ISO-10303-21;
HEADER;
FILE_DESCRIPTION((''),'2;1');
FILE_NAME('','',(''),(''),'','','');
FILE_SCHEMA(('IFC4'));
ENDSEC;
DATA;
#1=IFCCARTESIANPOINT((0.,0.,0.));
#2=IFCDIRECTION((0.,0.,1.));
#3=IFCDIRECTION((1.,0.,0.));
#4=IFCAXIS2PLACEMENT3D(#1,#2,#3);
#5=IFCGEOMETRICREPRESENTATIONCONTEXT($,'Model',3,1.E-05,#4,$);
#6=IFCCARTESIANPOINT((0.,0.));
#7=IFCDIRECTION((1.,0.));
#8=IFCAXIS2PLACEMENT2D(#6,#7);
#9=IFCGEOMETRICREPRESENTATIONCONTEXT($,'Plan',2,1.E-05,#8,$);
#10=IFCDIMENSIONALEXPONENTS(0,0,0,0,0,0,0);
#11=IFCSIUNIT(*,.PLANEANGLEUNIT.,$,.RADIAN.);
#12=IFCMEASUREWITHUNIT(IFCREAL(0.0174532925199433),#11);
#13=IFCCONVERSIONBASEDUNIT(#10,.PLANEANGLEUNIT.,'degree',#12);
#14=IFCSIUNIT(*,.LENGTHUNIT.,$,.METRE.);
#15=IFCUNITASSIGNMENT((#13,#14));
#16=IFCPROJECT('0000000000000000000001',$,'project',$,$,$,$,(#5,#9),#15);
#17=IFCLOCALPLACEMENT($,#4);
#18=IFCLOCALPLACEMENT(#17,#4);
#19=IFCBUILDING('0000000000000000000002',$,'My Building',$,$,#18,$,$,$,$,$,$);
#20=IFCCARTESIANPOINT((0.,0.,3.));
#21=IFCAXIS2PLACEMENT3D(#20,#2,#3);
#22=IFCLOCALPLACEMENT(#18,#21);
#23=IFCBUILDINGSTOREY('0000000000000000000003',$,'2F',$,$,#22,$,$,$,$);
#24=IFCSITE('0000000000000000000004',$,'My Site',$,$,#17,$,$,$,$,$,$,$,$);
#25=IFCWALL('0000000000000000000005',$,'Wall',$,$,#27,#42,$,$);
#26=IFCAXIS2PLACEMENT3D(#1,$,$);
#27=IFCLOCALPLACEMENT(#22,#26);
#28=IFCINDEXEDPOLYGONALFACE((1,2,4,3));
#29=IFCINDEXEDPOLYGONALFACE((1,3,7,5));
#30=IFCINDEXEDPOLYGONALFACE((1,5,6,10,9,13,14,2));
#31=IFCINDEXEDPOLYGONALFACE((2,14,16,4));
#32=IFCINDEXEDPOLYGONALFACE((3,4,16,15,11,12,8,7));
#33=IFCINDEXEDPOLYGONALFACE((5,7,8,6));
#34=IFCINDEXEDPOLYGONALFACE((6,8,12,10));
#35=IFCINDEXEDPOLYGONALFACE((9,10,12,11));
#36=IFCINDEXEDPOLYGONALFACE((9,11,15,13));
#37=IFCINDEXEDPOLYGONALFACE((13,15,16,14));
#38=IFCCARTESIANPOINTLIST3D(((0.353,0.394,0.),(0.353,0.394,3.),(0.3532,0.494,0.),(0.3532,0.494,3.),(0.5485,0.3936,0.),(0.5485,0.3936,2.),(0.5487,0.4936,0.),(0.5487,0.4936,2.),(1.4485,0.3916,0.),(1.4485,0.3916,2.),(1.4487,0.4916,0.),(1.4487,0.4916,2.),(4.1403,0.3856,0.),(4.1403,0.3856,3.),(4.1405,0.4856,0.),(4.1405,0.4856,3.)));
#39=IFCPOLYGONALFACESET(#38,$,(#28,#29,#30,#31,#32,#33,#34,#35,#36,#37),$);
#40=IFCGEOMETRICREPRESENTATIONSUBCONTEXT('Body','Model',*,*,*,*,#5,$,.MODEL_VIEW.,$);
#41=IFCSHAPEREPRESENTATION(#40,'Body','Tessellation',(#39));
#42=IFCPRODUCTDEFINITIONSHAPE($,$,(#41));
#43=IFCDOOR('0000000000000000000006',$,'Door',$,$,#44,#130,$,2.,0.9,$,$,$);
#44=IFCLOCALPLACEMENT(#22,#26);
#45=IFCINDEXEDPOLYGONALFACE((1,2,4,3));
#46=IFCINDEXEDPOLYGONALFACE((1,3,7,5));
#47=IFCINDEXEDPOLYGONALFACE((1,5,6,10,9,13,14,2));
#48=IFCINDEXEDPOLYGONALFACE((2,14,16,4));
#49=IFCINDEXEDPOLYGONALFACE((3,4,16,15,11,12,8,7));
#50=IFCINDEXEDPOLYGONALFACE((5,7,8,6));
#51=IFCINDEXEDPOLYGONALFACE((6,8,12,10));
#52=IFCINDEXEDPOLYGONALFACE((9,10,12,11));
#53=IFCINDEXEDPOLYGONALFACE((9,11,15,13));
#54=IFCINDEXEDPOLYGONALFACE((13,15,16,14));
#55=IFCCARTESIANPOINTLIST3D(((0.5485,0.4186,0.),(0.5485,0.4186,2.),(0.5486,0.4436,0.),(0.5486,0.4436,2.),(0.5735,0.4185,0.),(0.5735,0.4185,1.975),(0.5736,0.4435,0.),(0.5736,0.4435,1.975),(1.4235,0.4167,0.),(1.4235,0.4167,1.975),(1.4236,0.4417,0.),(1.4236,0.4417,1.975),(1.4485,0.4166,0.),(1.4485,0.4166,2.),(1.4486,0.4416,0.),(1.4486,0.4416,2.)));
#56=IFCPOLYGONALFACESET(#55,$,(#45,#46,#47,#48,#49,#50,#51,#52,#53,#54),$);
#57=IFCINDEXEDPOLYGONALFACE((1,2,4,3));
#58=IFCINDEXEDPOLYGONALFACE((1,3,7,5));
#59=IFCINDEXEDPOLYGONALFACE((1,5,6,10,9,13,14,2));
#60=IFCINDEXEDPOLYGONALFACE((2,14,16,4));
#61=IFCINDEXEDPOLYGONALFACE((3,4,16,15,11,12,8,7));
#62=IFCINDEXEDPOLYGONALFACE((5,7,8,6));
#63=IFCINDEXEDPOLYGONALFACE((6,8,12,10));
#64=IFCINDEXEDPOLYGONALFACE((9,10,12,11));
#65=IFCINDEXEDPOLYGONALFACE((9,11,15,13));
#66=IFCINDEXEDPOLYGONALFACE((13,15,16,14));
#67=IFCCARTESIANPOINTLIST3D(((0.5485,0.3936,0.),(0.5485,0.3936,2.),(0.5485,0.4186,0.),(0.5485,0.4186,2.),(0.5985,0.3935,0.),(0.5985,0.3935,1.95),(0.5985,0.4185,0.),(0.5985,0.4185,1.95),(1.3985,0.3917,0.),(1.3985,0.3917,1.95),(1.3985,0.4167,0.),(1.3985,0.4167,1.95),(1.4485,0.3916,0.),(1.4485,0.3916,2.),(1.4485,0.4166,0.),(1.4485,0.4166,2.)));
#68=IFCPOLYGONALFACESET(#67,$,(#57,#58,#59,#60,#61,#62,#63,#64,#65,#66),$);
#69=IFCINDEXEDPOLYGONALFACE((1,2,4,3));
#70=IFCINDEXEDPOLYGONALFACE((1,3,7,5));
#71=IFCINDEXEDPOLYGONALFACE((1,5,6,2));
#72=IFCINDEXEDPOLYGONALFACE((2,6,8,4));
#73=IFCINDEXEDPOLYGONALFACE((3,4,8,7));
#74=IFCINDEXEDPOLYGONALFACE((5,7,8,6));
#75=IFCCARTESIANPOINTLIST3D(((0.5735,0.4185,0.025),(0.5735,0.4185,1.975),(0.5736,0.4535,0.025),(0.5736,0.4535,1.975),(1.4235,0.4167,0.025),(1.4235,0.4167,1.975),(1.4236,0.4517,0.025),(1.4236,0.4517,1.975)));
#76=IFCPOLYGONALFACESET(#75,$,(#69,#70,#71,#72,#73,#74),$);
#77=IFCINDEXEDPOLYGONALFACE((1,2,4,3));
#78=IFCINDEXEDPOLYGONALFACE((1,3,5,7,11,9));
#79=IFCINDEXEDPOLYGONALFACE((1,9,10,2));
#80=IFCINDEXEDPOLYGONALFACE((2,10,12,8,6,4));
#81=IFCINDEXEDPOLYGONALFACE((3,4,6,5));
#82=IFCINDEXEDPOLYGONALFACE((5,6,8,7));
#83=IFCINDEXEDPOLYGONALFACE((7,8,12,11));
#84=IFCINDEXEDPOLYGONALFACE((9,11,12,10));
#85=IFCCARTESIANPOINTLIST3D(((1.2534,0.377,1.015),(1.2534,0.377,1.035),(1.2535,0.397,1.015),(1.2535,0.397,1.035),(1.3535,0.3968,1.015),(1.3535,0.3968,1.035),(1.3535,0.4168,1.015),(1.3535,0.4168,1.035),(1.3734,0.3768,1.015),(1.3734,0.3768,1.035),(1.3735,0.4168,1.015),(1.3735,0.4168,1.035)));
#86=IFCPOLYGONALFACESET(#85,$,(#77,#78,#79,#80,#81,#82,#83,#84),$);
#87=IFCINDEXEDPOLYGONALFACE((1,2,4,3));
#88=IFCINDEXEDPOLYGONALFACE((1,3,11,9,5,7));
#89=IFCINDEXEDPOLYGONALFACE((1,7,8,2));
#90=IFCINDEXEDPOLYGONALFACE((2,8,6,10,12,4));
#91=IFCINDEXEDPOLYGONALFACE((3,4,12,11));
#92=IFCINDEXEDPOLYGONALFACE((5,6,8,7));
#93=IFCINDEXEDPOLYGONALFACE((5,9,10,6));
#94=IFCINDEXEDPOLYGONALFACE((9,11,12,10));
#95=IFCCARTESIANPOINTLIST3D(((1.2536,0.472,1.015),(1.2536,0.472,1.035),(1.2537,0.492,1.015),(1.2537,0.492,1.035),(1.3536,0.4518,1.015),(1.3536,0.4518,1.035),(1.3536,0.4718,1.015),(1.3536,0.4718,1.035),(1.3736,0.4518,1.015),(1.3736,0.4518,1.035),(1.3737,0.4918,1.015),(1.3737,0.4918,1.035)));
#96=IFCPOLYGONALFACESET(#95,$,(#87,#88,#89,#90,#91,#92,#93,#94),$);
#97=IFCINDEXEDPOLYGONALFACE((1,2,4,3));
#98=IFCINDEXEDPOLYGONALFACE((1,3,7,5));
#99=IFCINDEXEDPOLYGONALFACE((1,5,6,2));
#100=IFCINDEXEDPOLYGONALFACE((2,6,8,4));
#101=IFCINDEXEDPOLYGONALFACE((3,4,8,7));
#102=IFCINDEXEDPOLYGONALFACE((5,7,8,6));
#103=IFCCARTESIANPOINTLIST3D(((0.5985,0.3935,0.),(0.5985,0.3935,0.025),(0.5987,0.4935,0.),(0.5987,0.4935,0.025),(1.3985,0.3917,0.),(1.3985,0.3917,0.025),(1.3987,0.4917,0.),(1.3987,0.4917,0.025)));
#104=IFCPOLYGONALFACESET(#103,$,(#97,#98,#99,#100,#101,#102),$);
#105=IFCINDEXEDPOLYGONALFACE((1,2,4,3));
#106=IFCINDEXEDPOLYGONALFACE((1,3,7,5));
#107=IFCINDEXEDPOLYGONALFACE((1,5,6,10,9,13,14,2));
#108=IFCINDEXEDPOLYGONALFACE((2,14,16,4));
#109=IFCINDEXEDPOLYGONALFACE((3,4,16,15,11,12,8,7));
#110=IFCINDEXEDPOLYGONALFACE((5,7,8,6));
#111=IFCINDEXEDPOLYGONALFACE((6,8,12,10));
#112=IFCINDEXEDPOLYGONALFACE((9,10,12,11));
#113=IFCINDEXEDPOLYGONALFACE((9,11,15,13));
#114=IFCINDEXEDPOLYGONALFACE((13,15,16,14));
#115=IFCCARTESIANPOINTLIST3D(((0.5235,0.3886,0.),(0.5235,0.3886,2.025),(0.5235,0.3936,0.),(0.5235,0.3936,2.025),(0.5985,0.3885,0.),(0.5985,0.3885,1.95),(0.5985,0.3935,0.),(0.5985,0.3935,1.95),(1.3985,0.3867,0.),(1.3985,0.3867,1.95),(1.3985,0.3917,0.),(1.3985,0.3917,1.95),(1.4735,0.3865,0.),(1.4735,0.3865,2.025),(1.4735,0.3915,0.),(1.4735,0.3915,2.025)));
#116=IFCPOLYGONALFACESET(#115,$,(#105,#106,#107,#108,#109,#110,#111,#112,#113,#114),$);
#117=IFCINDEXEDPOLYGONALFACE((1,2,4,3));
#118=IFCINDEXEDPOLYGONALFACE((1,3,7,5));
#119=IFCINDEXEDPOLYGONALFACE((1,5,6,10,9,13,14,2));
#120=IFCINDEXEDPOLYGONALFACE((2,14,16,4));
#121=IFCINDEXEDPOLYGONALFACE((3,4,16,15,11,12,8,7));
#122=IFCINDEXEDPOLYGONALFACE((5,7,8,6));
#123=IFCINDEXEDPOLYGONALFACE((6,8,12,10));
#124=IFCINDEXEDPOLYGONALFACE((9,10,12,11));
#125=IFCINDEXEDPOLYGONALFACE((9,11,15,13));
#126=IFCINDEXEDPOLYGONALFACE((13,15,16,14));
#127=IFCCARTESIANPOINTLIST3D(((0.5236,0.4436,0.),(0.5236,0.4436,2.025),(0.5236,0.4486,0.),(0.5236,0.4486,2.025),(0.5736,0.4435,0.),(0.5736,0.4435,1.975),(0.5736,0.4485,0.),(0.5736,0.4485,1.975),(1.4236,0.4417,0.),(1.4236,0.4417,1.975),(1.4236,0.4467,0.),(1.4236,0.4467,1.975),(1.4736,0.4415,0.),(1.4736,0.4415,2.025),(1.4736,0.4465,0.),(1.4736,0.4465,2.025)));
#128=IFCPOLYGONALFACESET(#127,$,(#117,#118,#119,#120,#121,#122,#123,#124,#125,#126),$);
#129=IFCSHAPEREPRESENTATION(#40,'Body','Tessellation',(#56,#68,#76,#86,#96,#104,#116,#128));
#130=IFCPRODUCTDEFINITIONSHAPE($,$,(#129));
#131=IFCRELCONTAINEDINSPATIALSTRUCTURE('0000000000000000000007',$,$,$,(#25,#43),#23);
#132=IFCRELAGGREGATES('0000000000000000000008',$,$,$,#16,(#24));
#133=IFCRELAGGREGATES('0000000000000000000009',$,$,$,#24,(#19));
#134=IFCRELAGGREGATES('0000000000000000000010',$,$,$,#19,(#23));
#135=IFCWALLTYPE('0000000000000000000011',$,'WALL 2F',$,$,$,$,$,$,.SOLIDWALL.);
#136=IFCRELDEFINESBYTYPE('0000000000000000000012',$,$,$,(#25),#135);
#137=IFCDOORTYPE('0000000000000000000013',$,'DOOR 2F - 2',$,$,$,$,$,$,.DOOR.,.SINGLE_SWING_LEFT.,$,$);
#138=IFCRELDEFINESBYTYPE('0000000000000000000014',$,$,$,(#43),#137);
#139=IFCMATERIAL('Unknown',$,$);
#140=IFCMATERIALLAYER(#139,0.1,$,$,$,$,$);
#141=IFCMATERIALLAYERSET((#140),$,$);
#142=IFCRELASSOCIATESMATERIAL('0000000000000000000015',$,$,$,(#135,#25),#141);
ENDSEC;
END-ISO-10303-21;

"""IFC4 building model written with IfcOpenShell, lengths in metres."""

from ifc_helpers import new_model, entity, si_unit, converted_unit, frame, origin_with_axes, origin_2d_with_axis, place, context, subcontext, project, spatial, line, indexed_curve, outline, extrude, shape, source, transform, mapped, material, layer, layer_set, layer_usage, type_object, type_shapes, element, fill, save


model = new_model("IFC4")

# Units and contexts
model_context = context("Model", 3, precision=1e-05, world=origin_with_axes())
plan_context = context("Plan", 2, precision=1e-05, world=origin_2d_with_axis())
body_context_1 = subcontext(model_context, "Body", "Model", "MODEL_VIEW")
body_context_2 = subcontext(plan_context, "Body", "Plan", "PLAN_VIEW")
ifc_project = project(units=[converted_unit("PLANEANGLEUNIT", "degree", entity("IfcReal", 0.0174532925199433), si_unit("PLANEANGLEUNIT", "RADIAN"), dimensions=[0, 0, 0, 0, 0, 0, 0]), si_unit("LENGTHUNIT", "METRE")], contexts=[model_context, plan_context])

# Site, building, storey
site_placement = place(None, origin_with_axes())
site = spatial("IfcSite", under=ifc_project, at=site_placement, Name="My Site")
building_placement = place(site_placement, origin_with_axes())
building = spatial("IfcBuilding", under=site, at=building_placement, Name="My Building")
storey_placement = place(building_placement, frame((0.0, 0.0, 3.0), z_axis=(0.0, 0.0, 1.0), x_axis=(1.0, 0.0, 0.0)))
storey = spatial("IfcBuildingStorey", under=building, at=storey_placement, Name="2F")

# Shared definitions
ifc_material = material(Name="Unknown")

# Shared definitions
ifc_layer = layer(ifc_material, 0.1)
ifc_layer_set = layer_set([ifc_layer])
wall_type = type_object("IfcWallType", Name="WALL 2F", PredefinedType="SOLIDWALL", material=ifc_layer_set)

# Wall, opening, door
shared_shape_1 = source(origin_with_axes(), body_context_1, "Body", "SweptSolid", [
    extrude(outline(indexed_curve([(0.0, 0.0), (0.9, 0.0), (0.9, 2.0), (0.0, 2.0)], segments=[line(1, 2, 3, 4, 1)])), frame((0.0, -0.6, 0.0), z_axis=(0.0, -1.0, 0.0), x_axis=(1.0, 0.0, 0.0)), (0.0, 0.0, -1.0), 1.2),
])
door_type_1 = type_object("IfcDoorType", Name="DOOR 2F - 2", OperationType="SINGLE_SWING_LEFT", PredefinedType="DOOR")
shared_shape_2 = source(origin_with_axes(), body_context_1, "Body", "SweptSolid", [
    extrude(outline(indexed_curve([(0.0, 0.0), (0.0, 2.0), (0.9, 2.0), (0.9, 0.0), (0.875, 0.0), (0.875, 1.975), (0.025, 1.975), (0.025, 0.0)], segments=[line(1, 2, 3, 4, 5, 6, 7, 8, 1)])), frame((0.0, 0.025, 0.0), z_axis=(0.0, -1.0, 0.0), x_axis=(1.0, 0.0, 0.0)), (0.0, 0.0, -1.0), 0.025),
    extrude(outline(indexed_curve([(0.0, 0.0), (0.0, 2.0), (0.9, 2.0), (0.9, 0.0), (0.85, 0.0), (0.85, 1.95), (0.05, 1.95), (0.05, 0.0)], segments=[line(1, 2, 3, 4, 5, 6, 7, 8, 1)])), frame((0.0, 0.0, 0.0), z_axis=(0.0, -1.0, 0.0), x_axis=(1.0, 0.0, 0.0)), (0.0, 0.0, -1.0), 0.025),
    extrude(outline(indexed_curve([(0.0, 0.0), (0.85, 0.0), (0.85, 0.035), (0.0, 0.035)], segments=[line(1, 2, 3, 4, 1)])), frame((0.025, 0.025, 0.025), z_axis=(0.0, 0.0, 1.0), x_axis=(1.0, 0.0, 0.0)), (0.0, 0.0, 1.0), 1.95),
    extrude(outline(indexed_curve([(0.0, 0.0), (0.0, -0.04), (-0.12, -0.04), (-0.12, -0.02), (-0.02, -0.02), (-0.02, 0.0)], segments=[line(1, 2, 3, 4, 5, 6, 1)])), frame((0.825, 0.025, 1.015), z_axis=(0.0, 0.0, 1.0), x_axis=(1.0, 0.0, 0.0)), (0.0, 0.0, 1.0), 0.02),
    extrude(outline(indexed_curve([(0.0, 0.0), (0.0, 0.04), (-0.12, 0.04), (-0.12, 0.02), (-0.02, 0.02), (-0.02, 0.0)], segments=[line(1, 2, 3, 4, 5, 6, 1)])), frame((0.825, 0.06, 1.015), z_axis=(0.0, 0.0, 1.0), x_axis=(1.0, 0.0, 0.0)), (0.0, 0.0, 1.0), 0.02),
    extrude(outline(indexed_curve([(0.0, 0.0), (0.8, 0.0), (0.8, 0.1), (0.0, 0.1)], segments=[line(1, 2, 3, 4, 1)])), frame((0.05, 0.0, 0.0), z_axis=(0.0, 0.0, 1.0), x_axis=(1.0, 0.0, 0.0)), (0.0, 0.0, 1.0), 0.025),
    extrude(outline(indexed_curve([(0.0, 0.0), (0.0, 2.025), (0.95, 2.025), (0.95, 0.0), (0.875, 0.0), (0.875, 1.95), (0.075, 1.95), (0.075, 0.0)], segments=[line(1, 2, 3, 4, 5, 6, 7, 8, 1)])), frame((-0.025, -0.005, 0.0), z_axis=(0.0, -1.0, 0.0), x_axis=(1.0, 0.0, 0.0)), (0.0, 0.0, -1.0), 0.005),
    extrude(outline(indexed_curve([(0.0, 0.0), (0.0, 2.025), (0.95, 2.025), (0.95, 0.0), (0.9, 0.0), (0.9, 1.975), (0.05, 1.975), (0.05, 0.0)], segments=[line(1, 2, 3, 4, 5, 6, 7, 8, 1)])), frame((-0.025, 0.05, 0.0), z_axis=(0.0, -1.0, 0.0), x_axis=(1.0, 0.0, 0.0)), (0.0, 0.0, -1.0), 0.005),
])
shared_shape_3 = source(origin_with_axes(), body_context_2, "Body", "Curve2D", [
    entity("IfcIndexedPolyCurve", entity("IfcCartesianPointList2D", [[0.0, 0.0], [0.0, 0.05], [0.025, 0.05], [0.025, 0.025], [0.05, 0.025], [0.05, 0.0]]), [entity("IfcLineIndex", [1, 2, 3, 4, 5, 6, 1])]),
    entity("IfcIndexedPolyCurve", entity("IfcCartesianPointList2D", [[0.9, 0.0], [0.9, 0.05], [0.875, 0.05], [0.875, 0.025], [0.85, 0.025], [0.85, 0.0]]), [entity("IfcLineIndex", [1, 2, 3, 4, 5, 6, 1])]),
    entity("IfcTrimmedCurve", entity("IfcEllipse", entity("IfcAxis2Placement2D", entity("IfcCartesianPoint", [0.06, 0.05]), entity("IfcDirection", [1.0, 0.0])), 0.815, 0.85), [entity("IfcCartesianPoint", [0.875, 0.05])], [entity("IfcCartesianPoint", [0.06, 0.9])], True, "CARTESIAN"),
    entity("IfcIndexedPolyCurve", entity("IfcCartesianPointList2D", [[0.025, 0.05], [0.06, 0.05], [0.06, 0.9], [0.025, 0.9]]), [entity("IfcLineIndex", [1, 2, 3, 4, 1])]),
])
type_shapes(door_type_1, [shared_shape_2, shared_shape_3])
ifc_layer_usage_1 = layer_usage(ifc_layer_set, "AXIS2", "POSITIVE", 0.0)
wall_1_placement = place(storey_placement, frame((0.353, 0.394, 0.0), z_axis=(0.0, 0.0, 1.0), x_axis=(0.999998, -0.002218, 0.0)))
wall_1 = element("IfcWall", 1, at=wall_1_placement, inside=storey, type_object=wall_type, material=ifc_layer_usage_1, Name="Wall", context=body_context_1, shape_type="SweptSolid", body=[
    extrude(outline(indexed_curve([(0.0, 0.0), (0.0, 0.1), (3.7873, 0.1), (3.7873, 0.0)], segments=[line(1, 2, 3, 4, 1)])), origin_with_axes(), (0.0, 0.0, 1.0), 3.0),
])
opening_1_placement = place(wall_1_placement, frame((0.1955, 0.0, 0.0), z_axis=(0.0, 0.0, 1.0), x_axis=(1.0, 0.0, 0.0)))
opening_1 = element("IfcOpeningElement", 2, at=opening_1_placement, cuts=wall_1, PredefinedType="OPENING", context=body_context_1, shape_type="MappedRepresentation", body=[
    mapped(shared_shape_1, transform((0.0, 0.0, 0.0), x_axis=(1.0, 0.0, 0.0), y_axis=(0.0, 1.0, 0.0), z_axis=(0.0, 0.0, 1.0), scale=1.0)),
])
door_1_placement = place(opening_1_placement, origin_with_axes())
door_1 = element("IfcDoor", 3, at=door_1_placement, inside=storey, type_object=door_type_1, Name="Door", OverallHeight=2.0, OverallWidth=0.9, shapes=[
    shape(body_context_1, "Body", "MappedRepresentation", [mapped(shared_shape_2, transform((0.0, 0.0, 0.0), x_axis=(1.0, 0.0, 0.0), y_axis=(0.0, 1.0, 0.0), z_axis=(0.0, 0.0, 1.0), scale=1.0))]),
    shape(body_context_2, "Body", "MappedRepresentation", [mapped(shared_shape_3, transform((0.0, 0.0, 0.0), x_axis=(1.0, 0.0, 0.0), y_axis=(0.0, 1.0, 0.0), z_axis=(0.0, 0.0, 1.0), scale=1.0))]),
])
fill(opening_1, door_1)

save(model, "model.ifc")
